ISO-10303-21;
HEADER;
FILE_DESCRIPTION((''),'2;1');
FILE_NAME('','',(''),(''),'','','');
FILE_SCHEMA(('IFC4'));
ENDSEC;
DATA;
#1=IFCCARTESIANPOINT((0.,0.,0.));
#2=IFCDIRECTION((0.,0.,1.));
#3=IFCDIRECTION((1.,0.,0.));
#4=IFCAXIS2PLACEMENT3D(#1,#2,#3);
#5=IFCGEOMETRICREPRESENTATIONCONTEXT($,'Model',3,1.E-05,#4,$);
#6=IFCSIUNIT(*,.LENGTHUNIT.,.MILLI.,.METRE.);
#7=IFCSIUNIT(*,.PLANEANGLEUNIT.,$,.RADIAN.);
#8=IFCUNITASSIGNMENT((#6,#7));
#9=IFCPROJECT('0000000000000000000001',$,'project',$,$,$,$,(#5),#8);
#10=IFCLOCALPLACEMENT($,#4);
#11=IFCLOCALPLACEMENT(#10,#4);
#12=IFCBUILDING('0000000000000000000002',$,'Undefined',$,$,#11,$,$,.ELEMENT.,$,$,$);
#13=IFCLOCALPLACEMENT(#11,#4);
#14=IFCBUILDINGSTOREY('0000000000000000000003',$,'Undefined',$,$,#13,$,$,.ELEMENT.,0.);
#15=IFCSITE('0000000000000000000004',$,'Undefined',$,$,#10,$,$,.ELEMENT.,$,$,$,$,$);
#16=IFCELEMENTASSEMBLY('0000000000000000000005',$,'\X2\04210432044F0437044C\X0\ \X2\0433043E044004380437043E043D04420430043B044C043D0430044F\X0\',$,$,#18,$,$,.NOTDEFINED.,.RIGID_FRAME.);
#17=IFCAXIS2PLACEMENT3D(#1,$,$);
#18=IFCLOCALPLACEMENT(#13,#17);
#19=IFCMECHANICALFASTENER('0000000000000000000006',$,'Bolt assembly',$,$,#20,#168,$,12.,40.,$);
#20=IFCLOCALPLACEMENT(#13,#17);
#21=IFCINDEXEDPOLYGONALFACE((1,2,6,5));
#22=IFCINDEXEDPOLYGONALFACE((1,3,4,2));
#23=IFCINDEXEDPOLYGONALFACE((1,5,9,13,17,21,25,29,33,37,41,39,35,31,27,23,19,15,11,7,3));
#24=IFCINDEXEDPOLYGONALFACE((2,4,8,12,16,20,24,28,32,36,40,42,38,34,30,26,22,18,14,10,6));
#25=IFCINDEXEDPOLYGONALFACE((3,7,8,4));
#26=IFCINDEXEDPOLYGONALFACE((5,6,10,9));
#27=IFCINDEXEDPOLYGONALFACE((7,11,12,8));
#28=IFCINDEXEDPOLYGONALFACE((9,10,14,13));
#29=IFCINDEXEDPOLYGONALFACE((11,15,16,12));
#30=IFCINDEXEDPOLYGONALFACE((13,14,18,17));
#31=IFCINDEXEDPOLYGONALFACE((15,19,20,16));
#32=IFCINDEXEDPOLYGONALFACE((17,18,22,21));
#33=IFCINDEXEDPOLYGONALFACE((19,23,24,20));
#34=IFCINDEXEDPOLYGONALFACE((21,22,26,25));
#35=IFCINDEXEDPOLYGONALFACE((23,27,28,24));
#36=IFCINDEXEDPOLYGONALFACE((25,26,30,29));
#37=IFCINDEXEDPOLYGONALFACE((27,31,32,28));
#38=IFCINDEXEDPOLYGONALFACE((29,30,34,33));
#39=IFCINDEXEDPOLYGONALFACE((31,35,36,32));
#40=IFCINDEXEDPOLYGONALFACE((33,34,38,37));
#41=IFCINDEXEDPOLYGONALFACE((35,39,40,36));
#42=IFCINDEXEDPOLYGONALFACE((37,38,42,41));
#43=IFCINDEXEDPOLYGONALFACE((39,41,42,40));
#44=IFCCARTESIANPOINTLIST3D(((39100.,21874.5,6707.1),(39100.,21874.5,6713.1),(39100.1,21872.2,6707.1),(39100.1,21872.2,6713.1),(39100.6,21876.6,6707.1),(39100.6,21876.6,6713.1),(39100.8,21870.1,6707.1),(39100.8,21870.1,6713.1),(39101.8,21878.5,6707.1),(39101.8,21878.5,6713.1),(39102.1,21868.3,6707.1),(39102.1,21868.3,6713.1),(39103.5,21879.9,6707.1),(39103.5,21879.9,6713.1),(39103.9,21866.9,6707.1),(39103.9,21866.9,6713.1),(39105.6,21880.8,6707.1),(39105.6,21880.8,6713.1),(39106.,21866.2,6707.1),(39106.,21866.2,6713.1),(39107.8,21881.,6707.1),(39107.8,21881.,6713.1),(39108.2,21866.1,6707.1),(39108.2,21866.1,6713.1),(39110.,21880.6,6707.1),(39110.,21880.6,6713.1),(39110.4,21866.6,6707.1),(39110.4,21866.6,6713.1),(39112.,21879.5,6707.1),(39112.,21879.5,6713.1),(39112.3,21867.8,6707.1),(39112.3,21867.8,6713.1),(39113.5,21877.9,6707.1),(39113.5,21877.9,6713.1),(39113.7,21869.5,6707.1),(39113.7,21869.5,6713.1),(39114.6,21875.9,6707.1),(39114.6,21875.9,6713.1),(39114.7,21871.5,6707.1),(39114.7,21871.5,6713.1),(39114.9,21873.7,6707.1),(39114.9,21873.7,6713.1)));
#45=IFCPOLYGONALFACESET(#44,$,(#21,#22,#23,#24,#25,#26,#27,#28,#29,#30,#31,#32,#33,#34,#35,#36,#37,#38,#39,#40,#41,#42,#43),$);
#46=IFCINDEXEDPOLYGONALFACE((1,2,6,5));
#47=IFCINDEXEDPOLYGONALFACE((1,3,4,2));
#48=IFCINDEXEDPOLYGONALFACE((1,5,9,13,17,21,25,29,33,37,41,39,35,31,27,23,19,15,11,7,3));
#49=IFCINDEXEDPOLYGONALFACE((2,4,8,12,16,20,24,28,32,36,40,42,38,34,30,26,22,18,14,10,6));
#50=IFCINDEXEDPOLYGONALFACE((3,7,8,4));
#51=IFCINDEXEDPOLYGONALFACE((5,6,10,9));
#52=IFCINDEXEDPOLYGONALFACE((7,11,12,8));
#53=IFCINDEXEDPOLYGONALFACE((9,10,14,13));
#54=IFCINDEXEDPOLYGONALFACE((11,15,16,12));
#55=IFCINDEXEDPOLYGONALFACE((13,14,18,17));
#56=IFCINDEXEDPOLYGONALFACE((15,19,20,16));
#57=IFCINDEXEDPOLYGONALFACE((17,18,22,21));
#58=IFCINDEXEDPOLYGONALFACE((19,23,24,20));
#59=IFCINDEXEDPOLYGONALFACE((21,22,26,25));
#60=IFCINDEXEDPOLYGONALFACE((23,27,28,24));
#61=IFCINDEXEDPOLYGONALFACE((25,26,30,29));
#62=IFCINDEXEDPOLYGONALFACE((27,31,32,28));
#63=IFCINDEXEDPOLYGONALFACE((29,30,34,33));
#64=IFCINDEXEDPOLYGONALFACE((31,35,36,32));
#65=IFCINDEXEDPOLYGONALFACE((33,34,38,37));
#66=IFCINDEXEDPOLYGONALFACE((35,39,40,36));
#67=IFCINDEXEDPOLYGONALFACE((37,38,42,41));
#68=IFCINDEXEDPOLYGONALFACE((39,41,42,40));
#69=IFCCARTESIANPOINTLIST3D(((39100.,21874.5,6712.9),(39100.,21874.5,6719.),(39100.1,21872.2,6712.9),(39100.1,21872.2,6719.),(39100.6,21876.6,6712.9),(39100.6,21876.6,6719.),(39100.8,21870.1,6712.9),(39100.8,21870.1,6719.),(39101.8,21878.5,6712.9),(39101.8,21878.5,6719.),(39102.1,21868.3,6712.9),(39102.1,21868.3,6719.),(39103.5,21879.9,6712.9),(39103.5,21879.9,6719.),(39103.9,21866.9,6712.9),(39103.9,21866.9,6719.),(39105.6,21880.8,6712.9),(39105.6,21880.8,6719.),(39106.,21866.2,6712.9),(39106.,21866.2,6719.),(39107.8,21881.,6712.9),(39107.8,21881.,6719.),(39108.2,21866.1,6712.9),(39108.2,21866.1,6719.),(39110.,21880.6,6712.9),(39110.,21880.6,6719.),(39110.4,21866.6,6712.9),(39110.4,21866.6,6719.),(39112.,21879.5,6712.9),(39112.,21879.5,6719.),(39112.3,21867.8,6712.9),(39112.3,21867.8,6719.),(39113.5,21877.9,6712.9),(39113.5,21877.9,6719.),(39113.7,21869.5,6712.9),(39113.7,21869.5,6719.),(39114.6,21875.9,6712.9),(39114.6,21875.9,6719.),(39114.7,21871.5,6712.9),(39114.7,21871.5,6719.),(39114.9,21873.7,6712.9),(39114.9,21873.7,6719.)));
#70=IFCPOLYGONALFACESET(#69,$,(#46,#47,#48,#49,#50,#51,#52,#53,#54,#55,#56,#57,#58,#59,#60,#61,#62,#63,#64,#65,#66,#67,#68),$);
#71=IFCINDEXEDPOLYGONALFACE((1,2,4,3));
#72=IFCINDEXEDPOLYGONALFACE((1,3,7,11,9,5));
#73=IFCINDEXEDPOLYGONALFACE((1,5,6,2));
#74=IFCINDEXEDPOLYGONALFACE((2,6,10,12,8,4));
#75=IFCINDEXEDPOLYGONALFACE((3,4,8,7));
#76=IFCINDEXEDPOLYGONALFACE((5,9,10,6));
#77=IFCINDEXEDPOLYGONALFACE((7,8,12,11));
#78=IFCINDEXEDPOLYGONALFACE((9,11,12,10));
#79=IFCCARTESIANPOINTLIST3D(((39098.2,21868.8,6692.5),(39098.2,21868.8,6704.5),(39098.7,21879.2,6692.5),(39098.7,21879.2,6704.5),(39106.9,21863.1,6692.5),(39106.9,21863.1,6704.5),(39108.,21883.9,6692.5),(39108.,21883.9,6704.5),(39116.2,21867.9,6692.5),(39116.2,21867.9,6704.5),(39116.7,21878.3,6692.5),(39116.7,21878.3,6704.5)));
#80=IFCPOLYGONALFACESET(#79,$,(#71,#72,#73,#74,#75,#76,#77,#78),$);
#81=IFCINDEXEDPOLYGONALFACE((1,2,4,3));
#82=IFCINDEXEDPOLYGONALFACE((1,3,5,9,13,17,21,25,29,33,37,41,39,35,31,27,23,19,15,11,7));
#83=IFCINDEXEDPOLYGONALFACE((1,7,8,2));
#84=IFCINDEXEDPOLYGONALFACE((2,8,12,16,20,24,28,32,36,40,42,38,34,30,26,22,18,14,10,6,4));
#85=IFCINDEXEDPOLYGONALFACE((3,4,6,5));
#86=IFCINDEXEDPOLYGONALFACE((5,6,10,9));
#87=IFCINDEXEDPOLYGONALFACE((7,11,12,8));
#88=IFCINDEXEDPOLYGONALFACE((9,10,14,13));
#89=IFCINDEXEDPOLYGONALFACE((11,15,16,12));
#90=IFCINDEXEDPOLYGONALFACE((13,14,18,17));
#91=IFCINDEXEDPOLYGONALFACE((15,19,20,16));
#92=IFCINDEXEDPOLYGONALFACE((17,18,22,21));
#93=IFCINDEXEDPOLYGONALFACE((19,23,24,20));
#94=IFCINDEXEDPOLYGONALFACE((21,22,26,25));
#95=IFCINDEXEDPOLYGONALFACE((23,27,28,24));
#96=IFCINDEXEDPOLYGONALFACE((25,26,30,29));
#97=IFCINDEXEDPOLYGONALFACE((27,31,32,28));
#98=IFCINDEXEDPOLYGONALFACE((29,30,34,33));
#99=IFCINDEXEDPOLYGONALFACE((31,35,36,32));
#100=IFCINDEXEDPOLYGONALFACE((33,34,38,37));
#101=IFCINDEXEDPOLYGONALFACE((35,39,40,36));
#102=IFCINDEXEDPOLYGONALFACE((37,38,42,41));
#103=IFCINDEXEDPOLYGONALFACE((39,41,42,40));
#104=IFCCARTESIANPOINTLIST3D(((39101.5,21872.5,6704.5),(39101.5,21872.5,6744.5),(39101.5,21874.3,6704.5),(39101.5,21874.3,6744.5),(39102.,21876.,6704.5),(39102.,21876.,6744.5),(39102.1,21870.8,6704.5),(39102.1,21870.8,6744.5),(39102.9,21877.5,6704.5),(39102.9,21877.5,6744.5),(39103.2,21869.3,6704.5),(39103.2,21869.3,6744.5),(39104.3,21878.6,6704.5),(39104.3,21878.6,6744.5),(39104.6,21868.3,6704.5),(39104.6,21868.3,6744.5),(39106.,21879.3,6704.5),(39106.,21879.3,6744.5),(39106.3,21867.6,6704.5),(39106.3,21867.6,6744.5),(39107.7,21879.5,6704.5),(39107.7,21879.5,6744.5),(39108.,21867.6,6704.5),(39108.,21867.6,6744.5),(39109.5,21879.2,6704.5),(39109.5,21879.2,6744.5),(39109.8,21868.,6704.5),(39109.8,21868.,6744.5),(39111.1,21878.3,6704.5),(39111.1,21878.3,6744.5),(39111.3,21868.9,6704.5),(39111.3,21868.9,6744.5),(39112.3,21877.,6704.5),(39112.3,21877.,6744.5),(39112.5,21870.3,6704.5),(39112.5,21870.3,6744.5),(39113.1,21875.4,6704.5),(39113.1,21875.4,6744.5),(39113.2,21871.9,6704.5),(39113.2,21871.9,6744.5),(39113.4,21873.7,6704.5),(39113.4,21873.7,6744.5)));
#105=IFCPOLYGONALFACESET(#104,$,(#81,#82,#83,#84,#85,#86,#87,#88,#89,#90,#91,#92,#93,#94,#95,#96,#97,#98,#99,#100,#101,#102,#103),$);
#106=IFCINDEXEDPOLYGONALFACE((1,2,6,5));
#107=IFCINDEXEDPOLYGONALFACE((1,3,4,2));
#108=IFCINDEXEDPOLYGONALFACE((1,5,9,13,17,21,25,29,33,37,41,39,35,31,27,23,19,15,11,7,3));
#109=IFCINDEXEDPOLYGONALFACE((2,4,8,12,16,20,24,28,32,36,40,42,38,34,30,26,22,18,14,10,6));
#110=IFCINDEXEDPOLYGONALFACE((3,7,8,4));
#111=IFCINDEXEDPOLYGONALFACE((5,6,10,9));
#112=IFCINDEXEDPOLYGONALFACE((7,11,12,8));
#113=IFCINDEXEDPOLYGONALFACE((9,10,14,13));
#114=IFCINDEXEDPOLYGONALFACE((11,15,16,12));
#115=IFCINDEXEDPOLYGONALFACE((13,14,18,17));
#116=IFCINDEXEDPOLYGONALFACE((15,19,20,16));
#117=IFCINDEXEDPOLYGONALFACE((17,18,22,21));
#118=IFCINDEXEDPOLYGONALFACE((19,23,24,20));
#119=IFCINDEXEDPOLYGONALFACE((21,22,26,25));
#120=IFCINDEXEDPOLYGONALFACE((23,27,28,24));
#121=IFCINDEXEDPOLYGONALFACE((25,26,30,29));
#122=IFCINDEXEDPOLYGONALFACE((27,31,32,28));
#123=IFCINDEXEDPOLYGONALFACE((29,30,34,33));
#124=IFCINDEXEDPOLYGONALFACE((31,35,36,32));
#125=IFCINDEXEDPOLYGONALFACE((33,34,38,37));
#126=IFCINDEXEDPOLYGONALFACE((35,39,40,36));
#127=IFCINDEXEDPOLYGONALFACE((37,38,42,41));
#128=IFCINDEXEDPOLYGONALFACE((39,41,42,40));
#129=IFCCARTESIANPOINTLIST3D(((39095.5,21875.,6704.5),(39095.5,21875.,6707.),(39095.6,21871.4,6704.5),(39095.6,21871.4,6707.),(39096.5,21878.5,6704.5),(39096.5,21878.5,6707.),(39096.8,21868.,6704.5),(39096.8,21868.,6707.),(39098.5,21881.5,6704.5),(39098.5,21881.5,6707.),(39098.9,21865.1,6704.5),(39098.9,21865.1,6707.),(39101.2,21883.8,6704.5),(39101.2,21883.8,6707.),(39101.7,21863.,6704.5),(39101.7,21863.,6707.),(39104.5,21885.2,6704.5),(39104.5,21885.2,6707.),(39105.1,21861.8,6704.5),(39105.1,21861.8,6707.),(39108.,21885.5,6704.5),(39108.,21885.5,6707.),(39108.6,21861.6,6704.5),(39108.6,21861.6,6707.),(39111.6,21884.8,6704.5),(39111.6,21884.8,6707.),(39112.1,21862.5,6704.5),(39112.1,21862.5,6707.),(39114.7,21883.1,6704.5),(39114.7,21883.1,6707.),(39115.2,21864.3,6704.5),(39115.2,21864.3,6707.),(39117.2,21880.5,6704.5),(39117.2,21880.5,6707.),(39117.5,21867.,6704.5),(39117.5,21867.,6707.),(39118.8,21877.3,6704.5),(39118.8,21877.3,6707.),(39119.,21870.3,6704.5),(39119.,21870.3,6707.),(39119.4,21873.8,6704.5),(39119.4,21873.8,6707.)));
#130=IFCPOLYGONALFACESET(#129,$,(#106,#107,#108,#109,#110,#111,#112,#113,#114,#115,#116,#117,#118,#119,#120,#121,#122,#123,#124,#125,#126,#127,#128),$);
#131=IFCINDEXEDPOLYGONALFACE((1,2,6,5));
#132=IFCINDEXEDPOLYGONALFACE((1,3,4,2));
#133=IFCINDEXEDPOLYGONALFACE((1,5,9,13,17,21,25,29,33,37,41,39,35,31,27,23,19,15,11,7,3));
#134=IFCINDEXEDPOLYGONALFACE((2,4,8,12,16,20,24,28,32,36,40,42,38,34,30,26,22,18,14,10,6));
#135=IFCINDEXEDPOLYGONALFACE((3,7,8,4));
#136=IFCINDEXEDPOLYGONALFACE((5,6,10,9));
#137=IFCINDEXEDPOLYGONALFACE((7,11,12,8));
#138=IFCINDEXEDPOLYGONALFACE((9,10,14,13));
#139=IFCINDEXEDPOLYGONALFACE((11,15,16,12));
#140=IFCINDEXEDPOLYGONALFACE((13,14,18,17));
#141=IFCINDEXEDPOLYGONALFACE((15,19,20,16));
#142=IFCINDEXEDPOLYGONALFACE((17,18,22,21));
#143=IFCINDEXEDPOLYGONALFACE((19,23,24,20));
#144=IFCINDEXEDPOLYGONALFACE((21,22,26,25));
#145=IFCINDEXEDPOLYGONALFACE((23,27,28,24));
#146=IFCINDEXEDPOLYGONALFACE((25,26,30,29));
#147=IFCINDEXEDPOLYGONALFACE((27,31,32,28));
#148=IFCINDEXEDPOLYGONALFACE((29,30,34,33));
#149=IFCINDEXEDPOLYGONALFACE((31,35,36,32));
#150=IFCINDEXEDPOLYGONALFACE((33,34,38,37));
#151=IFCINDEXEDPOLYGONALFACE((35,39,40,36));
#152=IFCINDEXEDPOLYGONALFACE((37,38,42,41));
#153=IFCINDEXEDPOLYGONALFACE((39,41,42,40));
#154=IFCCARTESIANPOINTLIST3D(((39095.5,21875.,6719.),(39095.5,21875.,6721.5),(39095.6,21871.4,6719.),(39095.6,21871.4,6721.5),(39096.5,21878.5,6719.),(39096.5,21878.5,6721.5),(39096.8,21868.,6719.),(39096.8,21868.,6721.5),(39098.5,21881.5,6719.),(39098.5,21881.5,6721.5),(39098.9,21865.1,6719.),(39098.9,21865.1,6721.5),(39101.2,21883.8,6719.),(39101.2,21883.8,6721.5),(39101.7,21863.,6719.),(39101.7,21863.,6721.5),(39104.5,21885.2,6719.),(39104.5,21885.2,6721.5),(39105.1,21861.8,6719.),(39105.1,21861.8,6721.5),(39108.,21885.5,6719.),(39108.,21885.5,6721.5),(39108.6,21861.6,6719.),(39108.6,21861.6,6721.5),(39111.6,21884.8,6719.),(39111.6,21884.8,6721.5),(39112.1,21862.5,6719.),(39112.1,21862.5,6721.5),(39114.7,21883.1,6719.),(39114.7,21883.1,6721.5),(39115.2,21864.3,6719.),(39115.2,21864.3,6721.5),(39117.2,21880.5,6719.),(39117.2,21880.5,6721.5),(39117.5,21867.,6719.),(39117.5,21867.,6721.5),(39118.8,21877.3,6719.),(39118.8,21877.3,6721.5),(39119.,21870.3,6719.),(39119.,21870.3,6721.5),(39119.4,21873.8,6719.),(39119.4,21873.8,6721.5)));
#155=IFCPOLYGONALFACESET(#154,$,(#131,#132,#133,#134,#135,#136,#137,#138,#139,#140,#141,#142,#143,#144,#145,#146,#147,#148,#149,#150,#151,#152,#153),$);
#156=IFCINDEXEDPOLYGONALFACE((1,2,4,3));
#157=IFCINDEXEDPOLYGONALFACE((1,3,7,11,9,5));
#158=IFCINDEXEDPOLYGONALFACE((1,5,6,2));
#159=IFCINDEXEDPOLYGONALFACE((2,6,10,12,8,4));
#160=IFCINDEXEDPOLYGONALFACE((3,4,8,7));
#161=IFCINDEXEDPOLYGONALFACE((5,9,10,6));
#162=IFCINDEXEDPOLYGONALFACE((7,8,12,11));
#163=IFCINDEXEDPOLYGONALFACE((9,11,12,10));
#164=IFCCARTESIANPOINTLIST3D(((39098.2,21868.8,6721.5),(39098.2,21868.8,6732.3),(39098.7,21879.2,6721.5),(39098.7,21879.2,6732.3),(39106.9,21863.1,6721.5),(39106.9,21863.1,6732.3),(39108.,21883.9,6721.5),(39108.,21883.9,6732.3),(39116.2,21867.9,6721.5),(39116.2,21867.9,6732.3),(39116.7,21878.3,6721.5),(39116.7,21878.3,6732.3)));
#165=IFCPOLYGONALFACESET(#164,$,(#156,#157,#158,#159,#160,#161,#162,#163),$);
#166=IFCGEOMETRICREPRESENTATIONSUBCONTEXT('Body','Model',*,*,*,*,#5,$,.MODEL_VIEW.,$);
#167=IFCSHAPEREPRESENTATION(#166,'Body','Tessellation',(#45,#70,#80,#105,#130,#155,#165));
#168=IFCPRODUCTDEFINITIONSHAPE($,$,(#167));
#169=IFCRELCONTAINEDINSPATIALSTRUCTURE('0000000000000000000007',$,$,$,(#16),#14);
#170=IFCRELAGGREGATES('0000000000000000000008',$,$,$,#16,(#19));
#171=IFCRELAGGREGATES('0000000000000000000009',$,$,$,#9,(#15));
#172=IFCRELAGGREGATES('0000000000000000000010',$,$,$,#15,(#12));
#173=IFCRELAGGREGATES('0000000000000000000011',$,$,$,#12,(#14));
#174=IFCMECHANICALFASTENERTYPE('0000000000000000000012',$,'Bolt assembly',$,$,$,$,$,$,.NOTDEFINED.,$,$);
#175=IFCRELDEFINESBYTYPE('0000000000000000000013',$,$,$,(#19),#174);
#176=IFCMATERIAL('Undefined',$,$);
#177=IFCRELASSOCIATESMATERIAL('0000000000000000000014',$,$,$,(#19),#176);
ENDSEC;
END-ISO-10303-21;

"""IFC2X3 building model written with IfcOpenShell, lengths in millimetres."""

from ifc_helpers import new_model, si_unit, frame, origin_with_axes, origin_2d_with_axis, place, context, subcontext, project, spatial, polyline, circle, outline, extrude, source, transform, mapped, material, type_object, element, aggregate, save


model = new_model("IFC2X3")

# Units and contexts
model_context = context("Model", 3, precision=1e-05, world=origin_with_axes())
body_context = subcontext(model_context, "Body", "Model", "MODEL_VIEW")
ifc_project = project(units=[si_unit("LENGTHUNIT", "METRE", prefix="MILLI"), si_unit("PLANEANGLEUNIT", "RADIAN")], contexts=[model_context])

# Site, building, storey
site_placement = place(None, origin_with_axes())
site = spatial("IfcSite", under=ifc_project, at=site_placement, Name="Undefined", CompositionType="ELEMENT")
building_placement = place(site_placement, origin_with_axes())
building = spatial("IfcBuilding", under=site, at=building_placement, Name="Undefined", CompositionType="ELEMENT")
storey_placement = place(building_placement, origin_with_axes())
storey = spatial("IfcBuildingStorey", under=building, at=storey_placement, Name="Undefined", CompositionType="ELEMENT", Elevation=0.0)

# Element assembly
assembly_1_placement = place(storey_placement, origin_with_axes())
assembly_1 = element("IfcElementAssembly", 1, at=assembly_1_placement, inside=storey, Name="Связь горизонтальная", AssemblyPlace="NOTDEFINED", PredefinedType="RIGID_FRAME")

# Mechanical fastener
ifc_material_1 = material(Name="Undefined")
mechanical_fastener_type = type_object("IfcMechanicalFastenerType", Name="Bolt assembly")
shared_shape_1 = source(origin_with_axes(), body_context, "Body", "SweptSolid", [
    extrude(circle(Radius=7.5, at=origin_2d_with_axis()), frame((0.0, 0.1, 0.0), z_axis=(0.0, 1.0, 0.0), x_axis=(1.0, 0.0, 0.0)), (0.0, 0.0, 1.0), 6.0),
    extrude(circle(Radius=7.5, at=origin_2d_with_axis()), frame((0.0, 5.9, 0.0), z_axis=(0.0, 1.0, 0.0), x_axis=(1.0, 0.0, 0.0)), (0.0, 0.0, 1.0), 6.1),
    extrude(outline(polyline([(10.4, 0.0), (5.2, 9.0), (-5.2, 9.0), (-10.4, 0.0), (-5.2, -9.0), (5.2, -9.0), (10.4, 0.0)])), frame((0.0, -14.5, 0.0), z_axis=(0.0, 1.0, 0.0), x_axis=(1.0, 0.0, 0.0)), (0.0, 0.0, 1.0), 12.0),
    extrude(circle(Radius=6.0, at=origin_2d_with_axis()), frame((0.0, -2.5, 0.0), z_axis=(0.0, 1.0, 0.0), x_axis=(1.0, 0.0, 0.0)), (0.0, 0.0, 1.0), 40.0),
    extrude(circle(Radius=12.0, at=origin_2d_with_axis()), frame((0.0, -2.5, 0.0), z_axis=(0.0, 1.0, 0.0), x_axis=(1.0, 0.0, 0.0)), (0.0, 0.0, 1.0), 2.5),
    extrude(circle(Radius=12.0, at=origin_2d_with_axis()), frame((0.0, 12.0, 0.0), z_axis=(0.0, 1.0, 0.0), x_axis=(1.0, 0.0, 0.0)), (0.0, 0.0, 1.0), 2.5),
    extrude(outline(polyline([(10.4, 0.0), (5.2, 9.0), (-5.2, 9.0), (-10.4, 0.0), (-5.2, -9.0), (5.2, -9.0), (10.4, 0.0)])), frame((0.0, 14.5, 0.0), z_axis=(0.0, 1.0, 0.0), x_axis=(1.0, 0.0, 0.0)), (0.0, 0.0, 1.0), 10.8),
])
mechanical_fastener_1_placement = place(assembly_1_placement, frame((39107.4, 21873.5, 6707.0), z_axis=(-0.542525, -0.840039, 0.0), x_axis=(0.840039, -0.542525, 0.0)))
mechanical_fastener_1 = element("IfcMechanicalFastener", 2, at=mechanical_fastener_1_placement, type_object=mechanical_fastener_type, material=ifc_material_1, Name="Bolt assembly", NominalDiameter=12.0, NominalLength=40.0, context=body_context, shape_type="MappedRepresentation", body=[
    mapped(shared_shape_1, transform((0.0, 0.0, 0.0))),
])
aggregate(assembly_1, [mechanical_fastener_1])

save(model, "model.ifc")
